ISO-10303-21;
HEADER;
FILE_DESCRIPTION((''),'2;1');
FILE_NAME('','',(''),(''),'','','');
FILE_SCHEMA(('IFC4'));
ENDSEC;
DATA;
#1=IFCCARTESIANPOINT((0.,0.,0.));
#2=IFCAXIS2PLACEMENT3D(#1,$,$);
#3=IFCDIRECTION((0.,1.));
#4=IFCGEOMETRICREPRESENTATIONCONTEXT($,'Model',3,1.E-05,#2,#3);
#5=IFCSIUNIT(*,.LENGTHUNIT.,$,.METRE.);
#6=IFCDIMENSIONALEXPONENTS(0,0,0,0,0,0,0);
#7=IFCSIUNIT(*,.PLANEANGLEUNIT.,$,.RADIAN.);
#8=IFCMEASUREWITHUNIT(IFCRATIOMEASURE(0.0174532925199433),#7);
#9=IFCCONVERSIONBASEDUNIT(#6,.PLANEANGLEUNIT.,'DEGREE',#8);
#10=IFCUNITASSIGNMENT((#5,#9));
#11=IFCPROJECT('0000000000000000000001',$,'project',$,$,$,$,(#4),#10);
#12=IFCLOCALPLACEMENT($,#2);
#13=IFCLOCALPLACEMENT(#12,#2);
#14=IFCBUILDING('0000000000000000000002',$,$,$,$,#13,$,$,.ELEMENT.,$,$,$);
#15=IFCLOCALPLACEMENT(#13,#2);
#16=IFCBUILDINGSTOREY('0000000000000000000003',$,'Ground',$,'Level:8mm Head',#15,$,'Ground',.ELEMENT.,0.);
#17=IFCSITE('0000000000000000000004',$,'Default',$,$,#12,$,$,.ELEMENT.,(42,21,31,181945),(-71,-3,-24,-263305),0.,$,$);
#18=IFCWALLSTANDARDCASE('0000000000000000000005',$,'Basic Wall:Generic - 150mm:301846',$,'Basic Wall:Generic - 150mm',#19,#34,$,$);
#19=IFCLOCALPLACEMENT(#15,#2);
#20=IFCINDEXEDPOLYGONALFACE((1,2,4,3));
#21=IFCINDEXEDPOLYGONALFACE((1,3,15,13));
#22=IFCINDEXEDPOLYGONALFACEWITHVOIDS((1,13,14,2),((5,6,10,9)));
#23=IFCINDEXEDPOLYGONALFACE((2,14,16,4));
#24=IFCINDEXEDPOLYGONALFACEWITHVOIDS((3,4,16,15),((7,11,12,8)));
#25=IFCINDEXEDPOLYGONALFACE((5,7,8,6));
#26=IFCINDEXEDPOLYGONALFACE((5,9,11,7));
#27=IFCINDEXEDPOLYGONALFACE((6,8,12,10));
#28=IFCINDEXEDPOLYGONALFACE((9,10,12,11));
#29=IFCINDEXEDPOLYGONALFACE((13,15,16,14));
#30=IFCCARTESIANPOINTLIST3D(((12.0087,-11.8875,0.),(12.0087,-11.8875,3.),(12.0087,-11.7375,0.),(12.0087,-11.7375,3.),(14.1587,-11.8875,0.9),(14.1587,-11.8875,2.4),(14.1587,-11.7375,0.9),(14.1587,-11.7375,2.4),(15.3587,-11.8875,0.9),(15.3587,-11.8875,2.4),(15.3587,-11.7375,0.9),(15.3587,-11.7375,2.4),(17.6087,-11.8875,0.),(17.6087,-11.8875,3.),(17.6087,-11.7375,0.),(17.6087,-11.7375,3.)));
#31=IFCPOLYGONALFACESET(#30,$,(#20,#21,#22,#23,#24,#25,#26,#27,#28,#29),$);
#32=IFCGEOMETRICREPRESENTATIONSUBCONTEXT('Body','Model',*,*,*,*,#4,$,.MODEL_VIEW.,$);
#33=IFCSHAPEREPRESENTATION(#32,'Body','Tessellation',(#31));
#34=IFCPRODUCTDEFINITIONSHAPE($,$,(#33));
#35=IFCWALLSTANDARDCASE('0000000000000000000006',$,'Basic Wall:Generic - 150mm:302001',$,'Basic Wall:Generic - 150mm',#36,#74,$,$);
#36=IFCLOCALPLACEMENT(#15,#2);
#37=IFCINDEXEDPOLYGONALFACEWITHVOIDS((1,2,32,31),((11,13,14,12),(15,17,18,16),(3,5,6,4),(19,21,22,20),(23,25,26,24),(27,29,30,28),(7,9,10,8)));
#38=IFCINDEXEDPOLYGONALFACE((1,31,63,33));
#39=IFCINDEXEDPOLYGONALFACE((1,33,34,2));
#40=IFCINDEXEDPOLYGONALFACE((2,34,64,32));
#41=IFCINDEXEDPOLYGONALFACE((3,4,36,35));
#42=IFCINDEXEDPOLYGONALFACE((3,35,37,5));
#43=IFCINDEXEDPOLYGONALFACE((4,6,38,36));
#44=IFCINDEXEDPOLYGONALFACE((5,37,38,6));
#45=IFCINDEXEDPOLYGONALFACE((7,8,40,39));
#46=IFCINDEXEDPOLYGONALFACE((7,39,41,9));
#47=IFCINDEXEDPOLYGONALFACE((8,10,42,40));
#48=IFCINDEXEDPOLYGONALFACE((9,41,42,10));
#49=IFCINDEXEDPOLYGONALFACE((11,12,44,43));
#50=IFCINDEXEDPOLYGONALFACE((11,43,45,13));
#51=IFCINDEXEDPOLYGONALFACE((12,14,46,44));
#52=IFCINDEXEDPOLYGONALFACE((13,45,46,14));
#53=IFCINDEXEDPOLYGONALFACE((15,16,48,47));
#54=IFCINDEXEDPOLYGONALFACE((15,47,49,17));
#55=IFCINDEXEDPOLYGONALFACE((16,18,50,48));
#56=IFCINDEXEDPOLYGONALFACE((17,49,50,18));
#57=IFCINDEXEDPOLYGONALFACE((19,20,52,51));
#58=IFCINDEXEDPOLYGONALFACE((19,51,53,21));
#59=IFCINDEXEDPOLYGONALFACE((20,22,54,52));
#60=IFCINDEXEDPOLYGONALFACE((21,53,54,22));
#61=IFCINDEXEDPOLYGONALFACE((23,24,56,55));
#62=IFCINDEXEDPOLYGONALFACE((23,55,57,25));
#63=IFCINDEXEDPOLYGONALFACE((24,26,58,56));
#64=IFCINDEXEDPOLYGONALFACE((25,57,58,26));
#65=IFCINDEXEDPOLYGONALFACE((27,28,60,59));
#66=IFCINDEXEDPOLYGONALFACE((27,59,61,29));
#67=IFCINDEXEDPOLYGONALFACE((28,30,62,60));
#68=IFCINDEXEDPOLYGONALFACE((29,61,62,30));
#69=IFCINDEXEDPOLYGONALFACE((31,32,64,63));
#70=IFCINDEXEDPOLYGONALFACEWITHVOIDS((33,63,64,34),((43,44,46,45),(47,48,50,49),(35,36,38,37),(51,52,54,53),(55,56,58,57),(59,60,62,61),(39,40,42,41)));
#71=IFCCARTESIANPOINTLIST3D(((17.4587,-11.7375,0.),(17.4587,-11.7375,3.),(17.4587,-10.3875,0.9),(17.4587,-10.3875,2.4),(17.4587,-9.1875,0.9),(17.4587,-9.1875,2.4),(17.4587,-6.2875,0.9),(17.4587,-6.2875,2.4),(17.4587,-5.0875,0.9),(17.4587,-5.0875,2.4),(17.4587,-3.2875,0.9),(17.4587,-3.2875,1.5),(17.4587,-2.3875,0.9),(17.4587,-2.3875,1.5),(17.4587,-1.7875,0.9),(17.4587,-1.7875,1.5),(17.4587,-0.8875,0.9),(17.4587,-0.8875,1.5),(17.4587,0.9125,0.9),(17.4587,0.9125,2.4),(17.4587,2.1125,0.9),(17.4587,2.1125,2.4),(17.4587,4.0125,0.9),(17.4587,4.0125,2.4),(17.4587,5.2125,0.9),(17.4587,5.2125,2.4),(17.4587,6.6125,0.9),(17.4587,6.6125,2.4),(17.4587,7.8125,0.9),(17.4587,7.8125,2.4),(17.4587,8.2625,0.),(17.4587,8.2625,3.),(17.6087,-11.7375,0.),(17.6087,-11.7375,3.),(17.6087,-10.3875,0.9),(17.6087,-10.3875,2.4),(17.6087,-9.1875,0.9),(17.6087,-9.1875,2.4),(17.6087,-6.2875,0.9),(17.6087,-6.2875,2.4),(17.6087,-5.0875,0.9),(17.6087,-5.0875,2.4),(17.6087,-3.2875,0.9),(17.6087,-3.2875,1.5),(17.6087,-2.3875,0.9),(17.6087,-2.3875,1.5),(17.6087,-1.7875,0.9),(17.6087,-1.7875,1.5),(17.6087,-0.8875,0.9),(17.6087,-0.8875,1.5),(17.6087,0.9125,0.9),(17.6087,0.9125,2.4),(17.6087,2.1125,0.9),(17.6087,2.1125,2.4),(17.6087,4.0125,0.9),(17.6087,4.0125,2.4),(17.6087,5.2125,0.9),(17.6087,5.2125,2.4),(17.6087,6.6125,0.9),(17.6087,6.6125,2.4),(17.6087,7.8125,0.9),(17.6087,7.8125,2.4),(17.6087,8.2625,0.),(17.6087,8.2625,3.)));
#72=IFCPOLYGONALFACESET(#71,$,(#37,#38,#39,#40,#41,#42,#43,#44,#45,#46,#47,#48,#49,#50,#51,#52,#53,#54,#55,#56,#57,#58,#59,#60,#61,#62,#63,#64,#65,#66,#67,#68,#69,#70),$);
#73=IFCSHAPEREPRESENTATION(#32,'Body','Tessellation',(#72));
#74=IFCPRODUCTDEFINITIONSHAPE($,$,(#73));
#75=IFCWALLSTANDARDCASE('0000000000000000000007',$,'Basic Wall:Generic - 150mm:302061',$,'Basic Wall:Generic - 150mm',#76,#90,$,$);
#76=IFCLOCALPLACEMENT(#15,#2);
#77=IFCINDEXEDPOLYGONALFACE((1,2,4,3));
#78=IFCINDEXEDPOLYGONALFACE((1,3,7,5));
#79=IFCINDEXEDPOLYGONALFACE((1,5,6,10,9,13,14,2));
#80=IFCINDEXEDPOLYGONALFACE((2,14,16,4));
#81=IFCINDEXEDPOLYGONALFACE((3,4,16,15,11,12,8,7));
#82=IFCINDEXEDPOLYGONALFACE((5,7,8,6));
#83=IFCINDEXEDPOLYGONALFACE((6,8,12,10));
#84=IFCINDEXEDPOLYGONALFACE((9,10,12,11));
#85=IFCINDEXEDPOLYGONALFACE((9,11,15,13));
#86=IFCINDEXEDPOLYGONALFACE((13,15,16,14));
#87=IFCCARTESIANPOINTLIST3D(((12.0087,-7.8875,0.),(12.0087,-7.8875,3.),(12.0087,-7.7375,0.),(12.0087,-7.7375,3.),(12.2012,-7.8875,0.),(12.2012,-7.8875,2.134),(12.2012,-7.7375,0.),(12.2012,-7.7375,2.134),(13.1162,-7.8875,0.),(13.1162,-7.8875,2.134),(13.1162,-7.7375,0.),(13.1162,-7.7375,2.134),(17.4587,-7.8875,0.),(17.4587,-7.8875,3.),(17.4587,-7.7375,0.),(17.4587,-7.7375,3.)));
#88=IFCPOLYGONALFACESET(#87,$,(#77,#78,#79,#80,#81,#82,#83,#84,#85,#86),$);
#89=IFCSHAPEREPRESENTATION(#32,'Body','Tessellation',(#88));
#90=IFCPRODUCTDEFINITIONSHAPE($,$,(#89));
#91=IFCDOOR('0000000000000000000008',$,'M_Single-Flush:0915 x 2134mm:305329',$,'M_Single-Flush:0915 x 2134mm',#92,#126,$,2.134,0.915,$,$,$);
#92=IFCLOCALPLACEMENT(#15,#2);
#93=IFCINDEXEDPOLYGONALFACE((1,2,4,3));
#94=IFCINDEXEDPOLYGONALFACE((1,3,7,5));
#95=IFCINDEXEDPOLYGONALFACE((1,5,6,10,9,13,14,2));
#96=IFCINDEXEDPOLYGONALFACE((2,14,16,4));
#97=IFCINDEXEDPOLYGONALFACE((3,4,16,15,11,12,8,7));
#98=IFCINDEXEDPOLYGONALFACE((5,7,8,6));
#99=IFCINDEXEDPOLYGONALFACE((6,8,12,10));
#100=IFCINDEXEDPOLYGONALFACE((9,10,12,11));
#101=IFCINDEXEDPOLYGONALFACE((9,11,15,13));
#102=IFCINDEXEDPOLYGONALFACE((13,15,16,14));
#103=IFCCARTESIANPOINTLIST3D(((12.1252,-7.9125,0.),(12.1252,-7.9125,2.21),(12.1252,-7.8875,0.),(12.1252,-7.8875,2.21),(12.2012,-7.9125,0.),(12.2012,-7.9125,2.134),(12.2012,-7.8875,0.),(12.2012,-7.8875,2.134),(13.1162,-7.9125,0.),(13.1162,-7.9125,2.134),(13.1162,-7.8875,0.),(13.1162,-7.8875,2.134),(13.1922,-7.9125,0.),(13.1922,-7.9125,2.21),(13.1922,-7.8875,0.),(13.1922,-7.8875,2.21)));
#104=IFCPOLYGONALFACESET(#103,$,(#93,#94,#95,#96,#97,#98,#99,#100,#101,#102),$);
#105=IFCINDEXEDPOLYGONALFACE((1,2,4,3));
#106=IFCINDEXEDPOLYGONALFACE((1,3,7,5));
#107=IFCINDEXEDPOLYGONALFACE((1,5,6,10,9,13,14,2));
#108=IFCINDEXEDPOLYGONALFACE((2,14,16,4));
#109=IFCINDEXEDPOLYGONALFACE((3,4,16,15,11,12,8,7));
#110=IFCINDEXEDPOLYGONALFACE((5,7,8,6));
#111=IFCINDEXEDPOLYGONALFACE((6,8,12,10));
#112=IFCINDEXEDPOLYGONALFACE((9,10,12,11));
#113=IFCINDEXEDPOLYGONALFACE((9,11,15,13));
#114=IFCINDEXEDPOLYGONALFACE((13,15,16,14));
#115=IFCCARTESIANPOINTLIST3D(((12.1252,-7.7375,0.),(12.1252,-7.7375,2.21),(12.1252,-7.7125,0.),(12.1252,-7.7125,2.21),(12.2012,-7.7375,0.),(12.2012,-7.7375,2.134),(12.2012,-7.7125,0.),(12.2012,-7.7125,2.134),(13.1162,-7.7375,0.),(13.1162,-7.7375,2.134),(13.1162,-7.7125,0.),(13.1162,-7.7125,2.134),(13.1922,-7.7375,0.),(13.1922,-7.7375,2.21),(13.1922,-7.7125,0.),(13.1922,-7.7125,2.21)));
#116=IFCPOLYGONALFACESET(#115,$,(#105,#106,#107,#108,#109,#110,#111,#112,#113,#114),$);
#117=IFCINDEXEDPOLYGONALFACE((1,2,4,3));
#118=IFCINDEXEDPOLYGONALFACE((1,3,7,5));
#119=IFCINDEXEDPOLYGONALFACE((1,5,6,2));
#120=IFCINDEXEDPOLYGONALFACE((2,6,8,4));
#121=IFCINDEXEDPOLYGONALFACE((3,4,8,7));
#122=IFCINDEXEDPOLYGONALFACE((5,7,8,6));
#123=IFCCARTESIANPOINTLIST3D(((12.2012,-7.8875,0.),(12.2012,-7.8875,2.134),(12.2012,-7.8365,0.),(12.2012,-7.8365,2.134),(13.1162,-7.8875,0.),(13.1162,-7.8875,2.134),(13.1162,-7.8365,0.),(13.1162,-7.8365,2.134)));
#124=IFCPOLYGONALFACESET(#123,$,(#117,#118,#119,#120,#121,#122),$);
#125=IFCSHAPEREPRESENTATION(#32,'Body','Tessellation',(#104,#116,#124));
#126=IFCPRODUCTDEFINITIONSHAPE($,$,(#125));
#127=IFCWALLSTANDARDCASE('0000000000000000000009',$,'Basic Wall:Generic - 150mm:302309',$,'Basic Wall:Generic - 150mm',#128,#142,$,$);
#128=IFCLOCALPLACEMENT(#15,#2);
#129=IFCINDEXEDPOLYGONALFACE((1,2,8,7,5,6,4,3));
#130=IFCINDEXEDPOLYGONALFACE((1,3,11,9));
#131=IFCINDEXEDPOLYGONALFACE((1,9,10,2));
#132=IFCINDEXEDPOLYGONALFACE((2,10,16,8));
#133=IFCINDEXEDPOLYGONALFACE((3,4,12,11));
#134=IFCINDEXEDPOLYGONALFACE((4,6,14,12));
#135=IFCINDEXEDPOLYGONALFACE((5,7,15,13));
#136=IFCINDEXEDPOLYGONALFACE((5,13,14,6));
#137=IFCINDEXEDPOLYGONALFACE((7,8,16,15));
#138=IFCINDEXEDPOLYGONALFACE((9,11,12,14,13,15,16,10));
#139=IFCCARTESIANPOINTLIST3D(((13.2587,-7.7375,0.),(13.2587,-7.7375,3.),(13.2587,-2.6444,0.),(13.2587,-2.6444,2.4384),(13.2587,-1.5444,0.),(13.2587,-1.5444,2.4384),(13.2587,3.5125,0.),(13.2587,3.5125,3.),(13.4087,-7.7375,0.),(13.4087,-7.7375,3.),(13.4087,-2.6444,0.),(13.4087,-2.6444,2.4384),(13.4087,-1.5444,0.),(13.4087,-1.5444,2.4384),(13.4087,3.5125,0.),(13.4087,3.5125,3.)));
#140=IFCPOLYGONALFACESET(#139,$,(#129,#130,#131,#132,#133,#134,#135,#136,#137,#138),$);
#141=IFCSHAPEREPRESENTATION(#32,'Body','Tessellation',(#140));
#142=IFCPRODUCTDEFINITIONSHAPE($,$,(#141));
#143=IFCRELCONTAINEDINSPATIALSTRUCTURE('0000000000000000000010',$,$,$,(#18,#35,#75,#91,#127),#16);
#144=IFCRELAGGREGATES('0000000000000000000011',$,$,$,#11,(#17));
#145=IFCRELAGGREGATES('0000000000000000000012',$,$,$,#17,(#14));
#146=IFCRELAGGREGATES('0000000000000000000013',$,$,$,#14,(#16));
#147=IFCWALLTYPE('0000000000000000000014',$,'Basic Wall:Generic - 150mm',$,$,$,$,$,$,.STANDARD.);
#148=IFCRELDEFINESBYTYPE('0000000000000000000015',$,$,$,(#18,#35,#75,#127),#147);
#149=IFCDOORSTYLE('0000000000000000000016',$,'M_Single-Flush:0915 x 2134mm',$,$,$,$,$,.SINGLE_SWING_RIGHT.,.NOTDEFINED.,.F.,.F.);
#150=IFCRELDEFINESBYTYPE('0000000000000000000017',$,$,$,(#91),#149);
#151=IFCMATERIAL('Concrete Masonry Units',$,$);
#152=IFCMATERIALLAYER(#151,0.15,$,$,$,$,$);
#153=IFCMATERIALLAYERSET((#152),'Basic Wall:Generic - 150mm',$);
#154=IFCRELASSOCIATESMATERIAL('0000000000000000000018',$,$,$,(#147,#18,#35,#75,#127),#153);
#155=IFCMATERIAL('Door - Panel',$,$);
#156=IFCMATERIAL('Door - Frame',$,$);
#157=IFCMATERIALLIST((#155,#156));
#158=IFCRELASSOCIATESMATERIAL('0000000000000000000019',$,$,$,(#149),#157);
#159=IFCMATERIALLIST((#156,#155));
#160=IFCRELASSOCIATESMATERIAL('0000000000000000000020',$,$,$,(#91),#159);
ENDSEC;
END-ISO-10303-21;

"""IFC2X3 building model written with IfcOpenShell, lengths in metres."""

from ifc_helpers import new_model, entity, si_unit, converted_unit, direction, frame, frame_2d, origin, origin_2d_with_axis, place, context, subcontext, project, spatial, polyline, rectangle, outline, extrude, source, transform, mapped, material, material_list, layer, layer_set, layer_usage, type_object, type_shapes, element, fill, save


model = new_model("IFC2X3")

# Units and contexts
model_context = context("Model", 3, precision=1e-05, world=origin(), true_north=direction((0.0, 1.0)))
body_context = subcontext(model_context, "Body", "Model", "MODEL_VIEW")
ifc_project = project(units=[si_unit("LENGTHUNIT", "METRE"), converted_unit("PLANEANGLEUNIT", "DEGREE", entity("IfcRatioMeasure", 0.0174532925199433), si_unit("PLANEANGLEUNIT", "RADIAN"), dimensions=[0, 0, 0, 0, 0, 0, 0])], contexts=[model_context])

# Site, building, storey
site_placement = place(None, origin())
site = spatial("IfcSite", under=ifc_project, at=site_placement, Name="Default", CompositionType="ELEMENT", RefLatitude=(42, 21, 31, 181945), RefLongitude=(-71, -3, -24, -263305), RefElevation=0.0)
building_placement = place(site_placement, origin())
building = spatial("IfcBuilding", under=site, at=building_placement, CompositionType="ELEMENT")
storey_placement = place(building_placement, origin())
storey = spatial("IfcBuildingStorey", under=building, at=storey_placement, Name="Ground", ObjectType="Level:8mm Head", LongName="Ground", CompositionType="ELEMENT", Elevation=0.0)

# Wall, opening
ifc_material_1 = material(Name="Concrete Masonry Units")
ifc_layer = layer(ifc_material_1, 0.15)
ifc_layer_set = layer_set([ifc_layer], Name="Basic Wall:Generic - 150mm")
ifc_layer_usage_1 = layer_usage(ifc_layer_set, "AXIS2", "POSITIVE", -0.075)
wall_type = type_object("IfcWallType", Name="Basic Wall:Generic - 150mm", PredefinedType="STANDARD", material=ifc_layer_set)
wall_1_placement = place(storey_placement, frame((12.0087, -11.8125, 0.0)))
wall_1 = element("IfcWallStandardCase", 1, at=wall_1_placement, inside=storey, type_object=wall_type, material=ifc_layer_usage_1, Name="Basic Wall:Generic - 150mm:301846", ObjectType="Basic Wall:Generic - 150mm", context=body_context, shape_type="SweptSolid", body=[
    extrude(rectangle(XDim=5.6, YDim=0.15, at=frame_2d((2.8, 0.0), x_axis=(-1.0, 0.0))), origin(), (0.0, 0.0, 1.0), 3.0),
])
opening_1_placement = place(wall_1_placement, frame((2.15, -0.075, 0.9)))
element("IfcOpeningElement", 2, at=opening_1_placement, cuts=wall_1, ObjectType="Opening", context=body_context, shape_type="SweptSolid", body=[
    extrude(rectangle(XDim=1.5, YDim=1.2, at=frame_2d((0.75, 0.6), x_axis=(-1.0, 0.0))), frame((0.0, 0.0, 0.0), z_axis=(0.0, 1.0, 0.0), x_axis=(0.0, 0.0, 1.0)), (0.0, 0.0, 1.0), 0.15),
])

# Wall, openings
ifc_layer_usage_2 = layer_usage(ifc_layer_set, "AXIS2", "NEGATIVE", 0.075)
wall_2_placement = place(storey_placement, frame((17.5337, -11.7375, 0.0), z_axis=(0.0, 0.0, 1.0), x_axis=(0.0, 1.0, 0.0)))
wall_2 = element("IfcWallStandardCase", 3, at=wall_2_placement, inside=storey, type_object=wall_type, material=ifc_layer_usage_2, Name="Basic Wall:Generic - 150mm:302001", ObjectType="Basic Wall:Generic - 150mm", context=body_context, shape_type="SweptSolid", body=[
    extrude(rectangle(XDim=20.0, YDim=0.15, at=frame_2d((10.0, 0.0), x_axis=(-1.0, 0.0))), origin(), (0.0, 0.0, 1.0), 3.0),
])
opening_2_placement = place(wall_2_placement, frame((16.95, 0.075, 0.9)))
element("IfcOpeningElement", 4, at=opening_2_placement, cuts=wall_2, ObjectType="Opening", context=body_context, shape_type="SweptSolid", body=[
    extrude(rectangle(XDim=1.5, YDim=1.2, at=frame_2d((0.75, 0.6), x_axis=(-1.0, 0.0))), frame((0.0, 0.0, 0.0), z_axis=(0.0, -1.0, 0.0), x_axis=(0.0, 0.0, 1.0)), (0.0, 0.0, 1.0), 0.15),
])
opening_3_placement = place(wall_2_placement, frame((19.55, 0.075, 0.9)))
element("IfcOpeningElement", 5, at=opening_3_placement, cuts=wall_2, ObjectType="Opening", context=body_context, shape_type="SweptSolid", body=[
    extrude(rectangle(XDim=1.5, YDim=1.2, at=frame_2d((0.75, 0.6), x_axis=(-1.0, 0.0))), frame((0.0, 0.0, 0.0), z_axis=(0.0, -1.0, 0.0), x_axis=(0.0, 0.0, 1.0)), (0.0, 0.0, 1.0), 0.15),
])
opening_4_placement = place(wall_2_placement, frame((12.65, -0.075, 0.9)))
element("IfcOpeningElement", 6, at=opening_4_placement, cuts=wall_2, ObjectType="Opening", context=body_context, shape_type="SweptSolid", body=[
    extrude(rectangle(XDim=1.5, YDim=1.2, at=frame_2d((0.75, 0.6), x_axis=(-1.0, 0.0))), frame((0.0, 0.0, 0.0), z_axis=(0.0, 1.0, 0.0), x_axis=(0.0, 0.0, 1.0)), (0.0, 0.0, 1.0), 0.15),
])
opening_5_placement = place(wall_2_placement, frame((5.45, -0.075, 0.9)))
element("IfcOpeningElement", 7, at=opening_5_placement, cuts=wall_2, ObjectType="Opening", context=body_context, shape_type="SweptSolid", body=[
    extrude(rectangle(XDim=1.5, YDim=1.2, at=frame_2d((0.75, 0.6), x_axis=(-1.0, 0.0))), frame((0.0, 0.0, 0.0), z_axis=(0.0, 1.0, 0.0), x_axis=(0.0, 0.0, 1.0)), (0.0, 0.0, 1.0), 0.15),
])
opening_6_placement = place(wall_2_placement, frame((1.35, -0.075, 0.9)))
element("IfcOpeningElement", 8, at=opening_6_placement, cuts=wall_2, ObjectType="Opening", context=body_context, shape_type="SweptSolid", body=[
    extrude(rectangle(XDim=1.5, YDim=1.2, at=frame_2d((0.75, 0.6), x_axis=(-1.0, 0.0))), frame((0.0, 0.0, 0.0), z_axis=(0.0, 1.0, 0.0), x_axis=(0.0, 0.0, 1.0)), (0.0, 0.0, 1.0), 0.15),
])
opening_7_placement = place(wall_2_placement, frame((9.95, -0.075, 0.9)))
element("IfcOpeningElement", 9, at=opening_7_placement, cuts=wall_2, ObjectType="Opening", context=body_context, shape_type="SweptSolid", body=[
    extrude(rectangle(XDim=0.6, YDim=0.9, at=frame_2d((0.3, 0.45), x_axis=(-1.0, 0.0))), frame((0.0, 0.0, 0.0), z_axis=(0.0, 1.0, 0.0), x_axis=(0.0, 0.0, 1.0)), (0.0, 0.0, 1.0), 0.15),
])
opening_8_placement = place(wall_2_placement, frame((8.45, -0.075, 0.9)))
element("IfcOpeningElement", 10, at=opening_8_placement, cuts=wall_2, ObjectType="Opening", context=body_context, shape_type="SweptSolid", body=[
    extrude(rectangle(XDim=0.6, YDim=0.9, at=frame_2d((0.3, 0.45), x_axis=(-1.0, 0.0))), frame((0.0, 0.0, 0.0), z_axis=(0.0, 1.0, 0.0), x_axis=(0.0, 0.0, 1.0)), (0.0, 0.0, 1.0), 0.15),
])

# Wall, opening, door
ifc_layer_usage_3 = layer_usage(ifc_layer_set, "AXIS2", "NEGATIVE", 0.075)
wall_3_placement = place(storey_placement, frame((17.4587, -7.8125, 0.0), z_axis=(0.0, 0.0, 1.0), x_axis=(-1.0, 0.0, 0.0)))
wall_3 = element("IfcWallStandardCase", 11, at=wall_3_placement, inside=storey, type_object=wall_type, material=ifc_layer_usage_3, Name="Basic Wall:Generic - 150mm:302061", ObjectType="Basic Wall:Generic - 150mm", context=body_context, shape_type="SweptSolid", body=[
    extrude(rectangle(XDim=5.45, YDim=0.15, at=frame_2d((2.725, 0.0), x_axis=(-1.0, 0.0))), origin(), (0.0, 0.0, 1.0), 3.0),
])
opening_9_placement = place(wall_3_placement, frame((4.3425, -0.075, 0.0)))
opening_9 = element("IfcOpeningElement", 12, at=opening_9_placement, cuts=wall_3, ObjectType="Opening", context=body_context, shape_type="SweptSolid", body=[
    extrude(rectangle(XDim=0.915, YDim=2.134, at=frame_2d((1.067, 0.4575), x_axis=(0.0, 1.0))), frame((0.0, 0.0, 0.0), z_axis=(0.0, 1.0, 0.0), x_axis=(0.0, 0.0, 1.0)), (0.0, 0.0, 1.0), 0.15),
])
ifc_material_2 = material(Name="Door - Frame")
ifc_material_3 = material(Name="Door - Panel")
ifc_material_list_1 = material_list([ifc_material_2, ifc_material_3])
ifc_material_list_2 = material_list([ifc_material_3, ifc_material_2])
door_style_1 = type_object("IfcDoorStyle", Name="M_Single-Flush:0915 x 2134mm", ConstructionType="NOTDEFINED", OperationType="SINGLE_SWING_RIGHT", ParameterTakesPrecedence=False, Sizeable=False, material=ifc_material_list_2)
shared_shape_1 = source(origin(), body_context, "Body", "SweptSolid", [
    extrude(outline(polyline([(-0.5335, -1.124), (0.5335, -1.124), (0.5335, 1.086), (0.4575, 1.086), (0.4575, -1.048), (-0.4575, -1.048), (-0.4575, 1.086), (-0.5335, 1.086), (-0.5335, -1.124)])), frame((0.4575, 0.15, 1.086), z_axis=(0.0, 1.0, 0.0), x_axis=(1.0, 0.0, 0.0)), (0.0, 0.0, 1.0), 0.025),
    extrude(outline(polyline([(-1.124, -0.5335), (1.086, -0.5335), (1.086, -0.4575), (-1.048, -0.4575), (-1.048, 0.4575), (1.086, 0.4575), (1.086, 0.5335), (-1.124, 0.5335), (-1.124, -0.5335)])), frame((0.4575, -0.025, 1.086), z_axis=(0.0, 1.0, 0.0), x_axis=(0.0, 0.0, -1.0)), (0.0, 0.0, 1.0), 0.025),
    extrude(rectangle(XDim=0.051, YDim=0.915, at=frame_2d((0.0, 0.0), x_axis=(1.0, 0.0))), frame((0.4575, 0.1245, 0.0), z_axis=(0.0, 0.0, 1.0), x_axis=(0.0, 1.0, 0.0)), (0.0, 0.0, 1.0), 2.134),
])
type_shapes(door_style_1, [shared_shape_1])
door_1_placement = place(opening_9_placement, origin())
door_1 = element("IfcDoor", 13, at=door_1_placement, inside=storey, type_object=door_style_1, material=ifc_material_list_1, Name="M_Single-Flush:0915 x 2134mm:305329", ObjectType="M_Single-Flush:0915 x 2134mm", OverallHeight=2.134, OverallWidth=0.915, context=body_context, shape_type="MappedRepresentation", body=[
    mapped(shared_shape_1, transform((0.0, 0.0, 0.0), scale=1.0)),
])
fill(opening_9, door_1)

# Wall, opening
ifc_layer_usage_4 = layer_usage(ifc_layer_set, "AXIS2", "NEGATIVE", 0.075)
wall_4_placement = place(storey_placement, frame((13.3337, -7.7375, 0.0), z_axis=(0.0, 0.0, 1.0), x_axis=(0.0, 1.0, 0.0)))
wall_4 = element("IfcWallStandardCase", 14, at=wall_4_placement, inside=storey, type_object=wall_type, material=ifc_layer_usage_4, Name="Basic Wall:Generic - 150mm:302309", ObjectType="Basic Wall:Generic - 150mm", context=body_context, shape_type="SweptSolid", body=[
    extrude(rectangle(XDim=11.25, YDim=0.15, at=frame_2d((5.625, 0.0), x_axis=(-1.0, 0.0))), origin(), (0.0, 0.0, 1.0), 3.0),
])
opening_10_placement = place(wall_4_placement, origin())
element("IfcOpeningElement", 15, at=opening_10_placement, cuts=wall_4, ObjectType="Opening", context=body_context, shape_type="SweptSolid", body=[
    extrude(rectangle(XDim=2.4384, YDim=1.1, at=origin_2d_with_axis()), frame((5.6431, -0.075, 1.2192), z_axis=(0.0, 1.0, 0.0), x_axis=(0.0, 0.0, -1.0)), (0.0, 0.0, 1.0), 0.15),
])

save(model, "model.ifc")
